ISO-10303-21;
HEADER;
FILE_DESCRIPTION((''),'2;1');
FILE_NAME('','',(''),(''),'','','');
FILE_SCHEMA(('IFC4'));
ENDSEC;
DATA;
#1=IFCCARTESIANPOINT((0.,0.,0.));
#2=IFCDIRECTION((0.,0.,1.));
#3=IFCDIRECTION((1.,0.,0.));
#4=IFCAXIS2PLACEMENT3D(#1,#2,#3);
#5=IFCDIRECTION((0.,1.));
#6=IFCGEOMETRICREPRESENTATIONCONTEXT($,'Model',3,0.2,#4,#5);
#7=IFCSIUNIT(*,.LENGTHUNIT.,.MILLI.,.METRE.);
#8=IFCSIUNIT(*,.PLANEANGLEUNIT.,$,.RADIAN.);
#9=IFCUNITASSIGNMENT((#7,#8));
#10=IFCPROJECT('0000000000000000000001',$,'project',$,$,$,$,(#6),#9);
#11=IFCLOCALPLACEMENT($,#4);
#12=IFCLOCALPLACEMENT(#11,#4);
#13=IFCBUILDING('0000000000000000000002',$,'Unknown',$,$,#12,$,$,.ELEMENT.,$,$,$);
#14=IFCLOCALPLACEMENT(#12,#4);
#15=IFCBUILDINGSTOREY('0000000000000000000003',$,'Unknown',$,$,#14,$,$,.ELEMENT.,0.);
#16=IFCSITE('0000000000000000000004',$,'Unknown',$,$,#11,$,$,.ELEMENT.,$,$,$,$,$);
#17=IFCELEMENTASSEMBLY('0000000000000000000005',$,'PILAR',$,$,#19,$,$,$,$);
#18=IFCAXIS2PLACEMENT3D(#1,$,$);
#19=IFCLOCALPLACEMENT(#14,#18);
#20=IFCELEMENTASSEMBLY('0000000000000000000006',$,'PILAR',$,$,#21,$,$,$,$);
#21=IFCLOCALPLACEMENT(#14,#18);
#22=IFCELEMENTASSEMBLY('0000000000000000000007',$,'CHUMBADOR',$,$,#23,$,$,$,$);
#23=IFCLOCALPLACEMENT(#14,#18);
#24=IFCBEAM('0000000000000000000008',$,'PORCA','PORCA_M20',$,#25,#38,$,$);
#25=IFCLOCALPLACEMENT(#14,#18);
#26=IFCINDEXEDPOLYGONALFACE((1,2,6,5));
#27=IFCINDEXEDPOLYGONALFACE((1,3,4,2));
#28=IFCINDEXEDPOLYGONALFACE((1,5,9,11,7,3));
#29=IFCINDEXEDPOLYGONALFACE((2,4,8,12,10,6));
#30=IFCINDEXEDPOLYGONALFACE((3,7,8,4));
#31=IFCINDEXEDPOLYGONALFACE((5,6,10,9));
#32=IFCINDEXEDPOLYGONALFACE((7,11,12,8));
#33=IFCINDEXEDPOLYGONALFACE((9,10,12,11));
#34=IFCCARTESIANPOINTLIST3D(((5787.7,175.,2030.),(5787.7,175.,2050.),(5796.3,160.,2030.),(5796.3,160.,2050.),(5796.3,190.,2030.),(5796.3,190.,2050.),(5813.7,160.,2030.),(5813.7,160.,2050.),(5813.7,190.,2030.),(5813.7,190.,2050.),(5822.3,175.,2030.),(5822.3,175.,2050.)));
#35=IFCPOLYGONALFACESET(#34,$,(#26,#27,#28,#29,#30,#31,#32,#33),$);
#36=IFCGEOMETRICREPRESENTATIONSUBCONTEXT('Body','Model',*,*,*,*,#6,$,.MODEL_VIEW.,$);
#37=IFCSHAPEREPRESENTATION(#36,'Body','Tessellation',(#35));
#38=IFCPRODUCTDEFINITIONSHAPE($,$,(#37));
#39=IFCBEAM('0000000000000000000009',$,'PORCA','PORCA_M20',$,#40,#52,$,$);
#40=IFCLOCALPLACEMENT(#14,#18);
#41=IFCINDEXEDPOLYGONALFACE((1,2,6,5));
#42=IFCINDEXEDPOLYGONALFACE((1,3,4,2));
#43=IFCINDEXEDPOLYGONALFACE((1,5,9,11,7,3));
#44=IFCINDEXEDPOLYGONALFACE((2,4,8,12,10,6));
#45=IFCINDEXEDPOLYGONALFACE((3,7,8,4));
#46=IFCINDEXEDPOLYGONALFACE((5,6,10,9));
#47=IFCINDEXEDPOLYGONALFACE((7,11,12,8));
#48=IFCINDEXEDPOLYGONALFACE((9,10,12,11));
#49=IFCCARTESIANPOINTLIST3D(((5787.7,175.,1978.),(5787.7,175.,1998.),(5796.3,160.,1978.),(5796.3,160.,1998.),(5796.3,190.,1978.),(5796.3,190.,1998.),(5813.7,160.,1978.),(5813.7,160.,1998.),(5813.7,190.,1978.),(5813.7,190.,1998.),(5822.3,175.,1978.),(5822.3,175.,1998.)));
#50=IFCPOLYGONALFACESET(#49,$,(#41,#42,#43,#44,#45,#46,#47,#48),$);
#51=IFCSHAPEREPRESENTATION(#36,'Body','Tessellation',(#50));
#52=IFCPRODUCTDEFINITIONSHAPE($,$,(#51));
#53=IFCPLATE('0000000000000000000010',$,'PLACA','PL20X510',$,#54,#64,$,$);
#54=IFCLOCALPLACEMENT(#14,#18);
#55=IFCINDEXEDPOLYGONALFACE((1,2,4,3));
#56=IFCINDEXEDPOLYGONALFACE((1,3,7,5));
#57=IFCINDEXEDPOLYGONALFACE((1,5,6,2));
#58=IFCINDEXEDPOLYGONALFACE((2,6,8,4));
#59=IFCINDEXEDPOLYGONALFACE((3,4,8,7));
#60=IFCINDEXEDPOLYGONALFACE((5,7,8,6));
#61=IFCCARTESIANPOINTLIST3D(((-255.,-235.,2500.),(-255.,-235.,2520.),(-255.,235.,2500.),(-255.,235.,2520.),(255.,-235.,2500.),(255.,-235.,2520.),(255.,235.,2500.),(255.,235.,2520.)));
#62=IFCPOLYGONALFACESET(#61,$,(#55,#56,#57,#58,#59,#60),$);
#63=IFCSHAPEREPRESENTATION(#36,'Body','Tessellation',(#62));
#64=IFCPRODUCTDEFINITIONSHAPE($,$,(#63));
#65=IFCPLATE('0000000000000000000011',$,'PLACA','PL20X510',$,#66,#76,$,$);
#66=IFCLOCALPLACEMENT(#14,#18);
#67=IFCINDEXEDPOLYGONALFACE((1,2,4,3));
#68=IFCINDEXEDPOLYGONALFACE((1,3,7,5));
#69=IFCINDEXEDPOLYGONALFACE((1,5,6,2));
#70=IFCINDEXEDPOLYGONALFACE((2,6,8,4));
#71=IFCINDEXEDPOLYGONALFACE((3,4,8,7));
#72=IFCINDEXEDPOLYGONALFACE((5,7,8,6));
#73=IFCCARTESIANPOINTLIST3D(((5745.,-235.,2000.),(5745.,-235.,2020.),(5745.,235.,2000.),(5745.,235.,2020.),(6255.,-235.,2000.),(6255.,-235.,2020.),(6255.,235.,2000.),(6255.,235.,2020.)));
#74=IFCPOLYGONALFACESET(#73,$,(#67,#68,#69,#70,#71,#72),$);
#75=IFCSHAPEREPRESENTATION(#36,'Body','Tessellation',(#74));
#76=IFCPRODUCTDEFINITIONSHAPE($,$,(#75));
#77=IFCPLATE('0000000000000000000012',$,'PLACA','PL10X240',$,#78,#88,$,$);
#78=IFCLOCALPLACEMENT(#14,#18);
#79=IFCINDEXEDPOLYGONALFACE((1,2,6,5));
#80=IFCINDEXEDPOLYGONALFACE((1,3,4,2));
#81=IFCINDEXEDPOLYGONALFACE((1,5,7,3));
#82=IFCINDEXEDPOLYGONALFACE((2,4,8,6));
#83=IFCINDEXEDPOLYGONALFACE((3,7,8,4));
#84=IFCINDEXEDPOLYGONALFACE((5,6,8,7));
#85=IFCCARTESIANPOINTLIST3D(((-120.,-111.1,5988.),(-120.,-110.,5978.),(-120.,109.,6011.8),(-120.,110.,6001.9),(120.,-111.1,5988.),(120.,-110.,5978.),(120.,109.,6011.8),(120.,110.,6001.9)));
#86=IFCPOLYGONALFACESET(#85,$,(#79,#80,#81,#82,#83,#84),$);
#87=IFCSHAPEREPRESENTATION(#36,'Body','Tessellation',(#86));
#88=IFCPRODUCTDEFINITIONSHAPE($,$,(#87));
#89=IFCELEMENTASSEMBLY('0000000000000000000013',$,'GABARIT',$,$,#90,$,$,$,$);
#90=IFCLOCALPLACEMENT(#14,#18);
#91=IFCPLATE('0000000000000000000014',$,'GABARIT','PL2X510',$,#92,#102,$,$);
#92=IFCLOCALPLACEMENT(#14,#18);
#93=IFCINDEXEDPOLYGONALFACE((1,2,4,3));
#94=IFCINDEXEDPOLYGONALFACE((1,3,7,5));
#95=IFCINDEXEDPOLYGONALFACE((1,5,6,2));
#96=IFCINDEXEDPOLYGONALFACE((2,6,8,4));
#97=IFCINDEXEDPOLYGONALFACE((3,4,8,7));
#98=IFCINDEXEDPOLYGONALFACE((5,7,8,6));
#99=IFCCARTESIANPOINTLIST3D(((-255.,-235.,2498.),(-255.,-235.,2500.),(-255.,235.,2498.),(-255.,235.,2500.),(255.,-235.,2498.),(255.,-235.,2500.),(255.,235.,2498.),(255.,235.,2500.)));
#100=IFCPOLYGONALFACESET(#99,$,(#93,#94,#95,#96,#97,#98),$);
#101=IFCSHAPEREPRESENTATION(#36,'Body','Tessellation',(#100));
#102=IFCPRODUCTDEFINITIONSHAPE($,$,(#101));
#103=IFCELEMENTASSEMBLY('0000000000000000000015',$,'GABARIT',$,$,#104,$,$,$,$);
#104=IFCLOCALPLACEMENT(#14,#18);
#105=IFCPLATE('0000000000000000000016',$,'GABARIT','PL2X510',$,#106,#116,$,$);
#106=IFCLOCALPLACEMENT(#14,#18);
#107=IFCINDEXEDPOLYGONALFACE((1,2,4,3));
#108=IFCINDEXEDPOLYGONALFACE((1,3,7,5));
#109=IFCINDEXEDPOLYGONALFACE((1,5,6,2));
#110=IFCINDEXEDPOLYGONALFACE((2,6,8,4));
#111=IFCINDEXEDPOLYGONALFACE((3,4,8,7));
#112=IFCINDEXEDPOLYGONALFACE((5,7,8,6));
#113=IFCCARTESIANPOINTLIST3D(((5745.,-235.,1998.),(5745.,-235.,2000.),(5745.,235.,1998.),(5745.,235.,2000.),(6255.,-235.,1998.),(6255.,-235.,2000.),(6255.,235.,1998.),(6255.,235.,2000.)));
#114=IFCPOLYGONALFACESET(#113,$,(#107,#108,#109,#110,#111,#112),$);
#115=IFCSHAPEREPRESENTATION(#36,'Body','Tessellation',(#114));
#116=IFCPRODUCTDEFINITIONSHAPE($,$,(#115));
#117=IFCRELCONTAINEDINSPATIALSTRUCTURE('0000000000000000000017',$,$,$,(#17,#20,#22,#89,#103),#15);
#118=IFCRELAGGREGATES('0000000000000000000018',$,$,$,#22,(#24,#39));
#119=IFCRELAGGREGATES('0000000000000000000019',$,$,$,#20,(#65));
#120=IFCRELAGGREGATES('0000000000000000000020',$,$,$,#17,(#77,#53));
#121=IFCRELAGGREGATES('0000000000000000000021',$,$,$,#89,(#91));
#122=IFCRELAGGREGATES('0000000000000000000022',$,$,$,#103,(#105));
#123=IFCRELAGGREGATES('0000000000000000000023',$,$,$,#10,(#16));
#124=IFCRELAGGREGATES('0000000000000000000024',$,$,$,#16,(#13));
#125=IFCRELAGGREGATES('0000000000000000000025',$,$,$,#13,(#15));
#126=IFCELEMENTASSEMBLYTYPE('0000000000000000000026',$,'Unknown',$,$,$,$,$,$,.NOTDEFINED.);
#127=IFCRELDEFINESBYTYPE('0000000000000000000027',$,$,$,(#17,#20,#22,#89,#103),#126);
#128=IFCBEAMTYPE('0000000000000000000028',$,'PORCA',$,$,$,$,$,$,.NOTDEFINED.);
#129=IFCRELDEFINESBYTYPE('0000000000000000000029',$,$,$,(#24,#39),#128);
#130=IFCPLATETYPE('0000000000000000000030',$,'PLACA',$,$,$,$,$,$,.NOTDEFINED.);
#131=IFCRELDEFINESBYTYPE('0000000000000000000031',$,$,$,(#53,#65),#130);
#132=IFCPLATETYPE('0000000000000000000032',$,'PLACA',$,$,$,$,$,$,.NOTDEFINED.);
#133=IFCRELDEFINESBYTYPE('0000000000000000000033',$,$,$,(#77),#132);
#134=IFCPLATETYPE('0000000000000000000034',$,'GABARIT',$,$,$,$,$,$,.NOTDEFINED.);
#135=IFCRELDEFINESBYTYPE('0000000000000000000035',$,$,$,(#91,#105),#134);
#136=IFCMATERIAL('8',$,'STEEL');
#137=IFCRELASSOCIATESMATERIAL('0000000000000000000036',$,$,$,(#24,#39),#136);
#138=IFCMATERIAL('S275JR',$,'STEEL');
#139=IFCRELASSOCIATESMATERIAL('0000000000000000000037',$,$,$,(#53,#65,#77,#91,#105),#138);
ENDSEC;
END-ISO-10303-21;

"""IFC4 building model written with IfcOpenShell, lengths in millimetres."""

from ifc_helpers import new_model, si_unit, direction, frame, origin_with_axes, origin_2d_with_axis, place, context, subcontext, project, spatial, polyline, rectangle, outline, extrude, material, material_profile, profile_set, profile_usage, type_object, element, aggregate, save


model = new_model("IFC4")

# Units and contexts
model_context = context("Model", 3, precision=0.2, world=origin_with_axes(), true_north=direction((0.0, 1.0)))
body_context = subcontext(model_context, "Body", "Model", "MODEL_VIEW")
ifc_project = project(units=[si_unit("LENGTHUNIT", "METRE", prefix="MILLI"), si_unit("PLANEANGLEUNIT", "RADIAN")], contexts=[model_context])

# Site, building, storey
site_placement = place(None, origin_with_axes())
site = spatial("IfcSite", under=ifc_project, at=site_placement, Name="Unknown", CompositionType="ELEMENT")
building_placement = place(site_placement, origin_with_axes())
building = spatial("IfcBuilding", under=site, at=building_placement, Name="Unknown", CompositionType="ELEMENT")
storey_placement = place(building_placement, origin_with_axes())
storey = spatial("IfcBuildingStorey", under=building, at=storey_placement, Name="Unknown", CompositionType="ELEMENT", Elevation=0.0)

# Element assemblies
element_assembly_type = type_object("IfcElementAssemblyType", Name="Unknown", PredefinedType="NOTDEFINED")
assembly_1_placement = place(storey_placement, frame((0.0, 0.0, 2000.0), z_axis=(1.0, 0.0, 0.0), x_axis=(0.0, 0.0, 1.0)))
assembly_1 = element("IfcElementAssembly", 1, at=assembly_1_placement, inside=storey, type_object=element_assembly_type, Name="PILAR")
assembly_2_placement = place(storey_placement, frame((6000.0, 0.0, 2000.0), z_axis=(1.0, 0.0, 0.0), x_axis=(0.0, 0.0, 1.0)))
assembly_2 = element("IfcElementAssembly", 2, at=assembly_2_placement, inside=storey, type_object=element_assembly_type, Name="PILAR")

# Shared definitions
ifc_material_1 = material(Name="8", Category="STEEL")
ifc_material_profile_1 = material_profile(ifc_material_1, outline(polyline([(8.7, -15.0), (17.3, 0.0), (8.7, 15.0), (-8.7, 15.0), (-17.3, 0.0), (-8.7, -15.0), (8.7, -15.0)])), Name="PORCA_M20")
ifc_profile_set_1 = profile_set([ifc_material_profile_1])
ifc_profile_usage_1 = profile_usage(ifc_profile_set_1, cardinal=5)
ifc_material_2 = material(Name="S275JR", Category="STEEL")

# Element assembly, beams
assembly_3_placement = place(storey_placement, frame((5805.0, -175.0, 1945.0), z_axis=(1.0, 0.0, 0.0), x_axis=(0.0, 0.0, -1.0)))
assembly_3 = element("IfcElementAssembly", 3, at=assembly_3_placement, inside=storey, type_object=element_assembly_type, Name="CHUMBADOR")
beam_type_1 = type_object("IfcBeamType", Name="PORCA", PredefinedType="NOTDEFINED")
beam_1_placement = place(assembly_3_placement, frame((-105.0, 350.0, 0.0), z_axis=(0.0, 0.0, -1.0), x_axis=(1.0, 0.0, 0.0)))
beam_1 = element("IfcBeam", 4, at=beam_1_placement, type_object=beam_type_1, material=ifc_profile_usage_1, Name="PORCA", Description="PORCA_M20", context=body_context, shape_type="SolidModel", body=[
    extrude(outline(polyline([(8.7, -15.0), (17.3, 0.0), (8.7, 15.0), (-8.7, 15.0), (-17.3, 0.0), (-8.7, -15.0), (8.7, -15.0)])), frame((0.0, 0.0, 0.0), z_axis=(-1.0, 0.0, 0.0), x_axis=(0.0, 0.0, 1.0)), (0.0, 0.0, -1.0), 20.0),
])
beam_2_placement = place(assembly_3_placement, frame((-53.0, 350.0, 0.0), z_axis=(0.0, 0.0, -1.0), x_axis=(1.0, 0.0, 0.0)))
beam_2 = element("IfcBeam", 5, at=beam_2_placement, type_object=beam_type_1, material=ifc_profile_usage_1, Name="PORCA", Description="PORCA_M20", context=body_context, shape_type="SolidModel", body=[
    extrude(outline(polyline([(8.7, -15.0), (17.3, 0.0), (8.7, 15.0), (-8.7, 15.0), (-17.3, 0.0), (-8.7, -15.0), (8.7, -15.0)])), frame((0.0, 0.0, 0.0), z_axis=(-1.0, 0.0, 0.0), x_axis=(0.0, 0.0, 1.0)), (0.0, 0.0, -1.0), 20.0),
])
aggregate(assembly_3, [beam_1, beam_2])

# Plates
ifc_material_profile_2 = material_profile(ifc_material_2, rectangle(XDim=470.0, YDim=510.0, at=origin_2d_with_axis()), Name="PL20X510")
ifc_profile_set_2 = profile_set([ifc_material_profile_2])
ifc_profile_usage_2 = profile_usage(ifc_profile_set_2, cardinal=8)
plate_type_1 = type_object("IfcPlateType", Name="PLACA", PredefinedType="NOTDEFINED")
plate_1_placement = place(assembly_1_placement, frame((510.0, 235.0, 0.0), z_axis=(0.0, -1.0, 0.0), x_axis=(1.0, 0.0, 0.0)))
plate_1 = element("IfcPlate", 6, at=plate_1_placement, type_object=plate_type_1, material=ifc_profile_usage_2, Name="PLACA", Description="PL20X510", context=body_context, shape_type="SolidModel", body=[
    extrude(rectangle(XDim=470.0, YDim=510.0, at=origin_2d_with_axis()), frame((-10.0, 0.0, 235.0), z_axis=(-1.0, 0.0, 0.0), x_axis=(0.0, 0.0, 1.0)), (0.0, 0.0, -1.0), 20.0),
])
plate_2_placement = place(assembly_2_placement, frame((10.0, 235.0, 0.0), z_axis=(0.0, -1.0, 0.0), x_axis=(1.0, 0.0, 0.0)))
plate_2 = element("IfcPlate", 7, at=plate_2_placement, type_object=plate_type_1, material=ifc_profile_usage_2, Name="PLACA", Description="PL20X510", context=body_context, shape_type="SolidModel", body=[
    extrude(rectangle(XDim=470.0, YDim=510.0, at=origin_2d_with_axis()), frame((-10.0, 0.0, 235.0), z_axis=(-1.0, 0.0, 0.0), x_axis=(0.0, 0.0, 1.0)), (0.0, 0.0, -1.0), 20.0),
])
aggregate(assembly_2, [plate_2])
ifc_material_profile_3 = material_profile(ifc_material_2, rectangle(XDim=221.3, YDim=240.0, at=origin_2d_with_axis()), Name="PL10X240")
ifc_profile_set_3 = profile_set([ifc_material_profile_3])
ifc_profile_usage_3 = profile_usage(ifc_profile_set_3, cardinal=2)
plate_type_2 = type_object("IfcPlateType", Name="PLACA", PredefinedType="NOTDEFINED")
plate_3_placement = place(assembly_1_placement, frame((4006.8, -109.5, 0.0), z_axis=(-0.107703, 0.994183, 0.0), x_axis=(-0.994183, -0.107703, 0.0)))
plate_3 = element("IfcPlate", 8, at=plate_3_placement, type_object=plate_type_2, material=ifc_profile_usage_3, Name="PLACA", Description="PL10X240", context=body_context, shape_type="SolidModel", body=[
    extrude(rectangle(XDim=221.3, YDim=240.0, at=origin_2d_with_axis()), frame((-5.0, 0.0, 110.7), z_axis=(-1.0, 0.0, 0.0), x_axis=(0.0, 0.0, 1.0)), (0.0, 0.0, -1.0), 10.0),
])
aggregate(assembly_1, [plate_3, plate_1])

# Element assemblies, plates
assembly_4_placement = place(storey_placement, frame((0.0, 235.0, 2499.0), z_axis=(0.0, 0.0, 1.0), x_axis=(0.0, -1.0, 0.0)))
assembly_4 = element("IfcElementAssembly", 9, at=assembly_4_placement, inside=storey, type_object=element_assembly_type, Name="GABARIT")
ifc_material_profile_4 = material_profile(ifc_material_2, rectangle(XDim=470.0, YDim=510.0, at=origin_2d_with_axis()), Name="PL2X510")
ifc_profile_set_4 = profile_set([ifc_material_profile_4])
ifc_profile_usage_4 = profile_usage(ifc_profile_set_4, cardinal=2)
plate_type_3 = type_object("IfcPlateType", Name="GABARIT", PredefinedType="NOTDEFINED")
plate_4_placement = place(assembly_4_placement, frame((470.0, 0.0, 0.0), z_axis=(-1.0, 0.0, 0.0), x_axis=(0.0, 0.0, 1.0)))
plate_4 = element("IfcPlate", 10, at=plate_4_placement, type_object=plate_type_3, material=ifc_profile_usage_4, Name="GABARIT", Description="PL2X510", context=body_context, shape_type="SolidModel", body=[
    extrude(rectangle(XDim=470.0, YDim=510.0, at=origin_2d_with_axis()), frame((-1.0, 0.0, 235.0), z_axis=(-1.0, 0.0, 0.0), x_axis=(0.0, 0.0, 1.0)), (0.0, 0.0, -1.0), 2.0),
])
aggregate(assembly_4, [plate_4])
assembly_5_placement = place(storey_placement, frame((6000.0, 235.0, 1999.0), z_axis=(0.0, 0.0, 1.0), x_axis=(0.0, -1.0, 0.0)))
assembly_5 = element("IfcElementAssembly", 11, at=assembly_5_placement, inside=storey, type_object=element_assembly_type, Name="GABARIT")
plate_5_placement = place(assembly_5_placement, frame((470.0, 0.0, 0.0), z_axis=(-1.0, 0.0, 0.0), x_axis=(0.0, 0.0, 1.0)))
plate_5 = element("IfcPlate", 12, at=plate_5_placement, type_object=plate_type_3, material=ifc_profile_usage_4, Name="GABARIT", Description="PL2X510", context=body_context, shape_type="SolidModel", body=[
    extrude(rectangle(XDim=470.0, YDim=510.0, at=origin_2d_with_axis()), frame((-1.0, 0.0, 235.0), z_axis=(-1.0, 0.0, 0.0), x_axis=(0.0, 0.0, 1.0)), (0.0, 0.0, -1.0), 2.0),
])
aggregate(assembly_5, [plate_5])

save(model, "model.ifc")
